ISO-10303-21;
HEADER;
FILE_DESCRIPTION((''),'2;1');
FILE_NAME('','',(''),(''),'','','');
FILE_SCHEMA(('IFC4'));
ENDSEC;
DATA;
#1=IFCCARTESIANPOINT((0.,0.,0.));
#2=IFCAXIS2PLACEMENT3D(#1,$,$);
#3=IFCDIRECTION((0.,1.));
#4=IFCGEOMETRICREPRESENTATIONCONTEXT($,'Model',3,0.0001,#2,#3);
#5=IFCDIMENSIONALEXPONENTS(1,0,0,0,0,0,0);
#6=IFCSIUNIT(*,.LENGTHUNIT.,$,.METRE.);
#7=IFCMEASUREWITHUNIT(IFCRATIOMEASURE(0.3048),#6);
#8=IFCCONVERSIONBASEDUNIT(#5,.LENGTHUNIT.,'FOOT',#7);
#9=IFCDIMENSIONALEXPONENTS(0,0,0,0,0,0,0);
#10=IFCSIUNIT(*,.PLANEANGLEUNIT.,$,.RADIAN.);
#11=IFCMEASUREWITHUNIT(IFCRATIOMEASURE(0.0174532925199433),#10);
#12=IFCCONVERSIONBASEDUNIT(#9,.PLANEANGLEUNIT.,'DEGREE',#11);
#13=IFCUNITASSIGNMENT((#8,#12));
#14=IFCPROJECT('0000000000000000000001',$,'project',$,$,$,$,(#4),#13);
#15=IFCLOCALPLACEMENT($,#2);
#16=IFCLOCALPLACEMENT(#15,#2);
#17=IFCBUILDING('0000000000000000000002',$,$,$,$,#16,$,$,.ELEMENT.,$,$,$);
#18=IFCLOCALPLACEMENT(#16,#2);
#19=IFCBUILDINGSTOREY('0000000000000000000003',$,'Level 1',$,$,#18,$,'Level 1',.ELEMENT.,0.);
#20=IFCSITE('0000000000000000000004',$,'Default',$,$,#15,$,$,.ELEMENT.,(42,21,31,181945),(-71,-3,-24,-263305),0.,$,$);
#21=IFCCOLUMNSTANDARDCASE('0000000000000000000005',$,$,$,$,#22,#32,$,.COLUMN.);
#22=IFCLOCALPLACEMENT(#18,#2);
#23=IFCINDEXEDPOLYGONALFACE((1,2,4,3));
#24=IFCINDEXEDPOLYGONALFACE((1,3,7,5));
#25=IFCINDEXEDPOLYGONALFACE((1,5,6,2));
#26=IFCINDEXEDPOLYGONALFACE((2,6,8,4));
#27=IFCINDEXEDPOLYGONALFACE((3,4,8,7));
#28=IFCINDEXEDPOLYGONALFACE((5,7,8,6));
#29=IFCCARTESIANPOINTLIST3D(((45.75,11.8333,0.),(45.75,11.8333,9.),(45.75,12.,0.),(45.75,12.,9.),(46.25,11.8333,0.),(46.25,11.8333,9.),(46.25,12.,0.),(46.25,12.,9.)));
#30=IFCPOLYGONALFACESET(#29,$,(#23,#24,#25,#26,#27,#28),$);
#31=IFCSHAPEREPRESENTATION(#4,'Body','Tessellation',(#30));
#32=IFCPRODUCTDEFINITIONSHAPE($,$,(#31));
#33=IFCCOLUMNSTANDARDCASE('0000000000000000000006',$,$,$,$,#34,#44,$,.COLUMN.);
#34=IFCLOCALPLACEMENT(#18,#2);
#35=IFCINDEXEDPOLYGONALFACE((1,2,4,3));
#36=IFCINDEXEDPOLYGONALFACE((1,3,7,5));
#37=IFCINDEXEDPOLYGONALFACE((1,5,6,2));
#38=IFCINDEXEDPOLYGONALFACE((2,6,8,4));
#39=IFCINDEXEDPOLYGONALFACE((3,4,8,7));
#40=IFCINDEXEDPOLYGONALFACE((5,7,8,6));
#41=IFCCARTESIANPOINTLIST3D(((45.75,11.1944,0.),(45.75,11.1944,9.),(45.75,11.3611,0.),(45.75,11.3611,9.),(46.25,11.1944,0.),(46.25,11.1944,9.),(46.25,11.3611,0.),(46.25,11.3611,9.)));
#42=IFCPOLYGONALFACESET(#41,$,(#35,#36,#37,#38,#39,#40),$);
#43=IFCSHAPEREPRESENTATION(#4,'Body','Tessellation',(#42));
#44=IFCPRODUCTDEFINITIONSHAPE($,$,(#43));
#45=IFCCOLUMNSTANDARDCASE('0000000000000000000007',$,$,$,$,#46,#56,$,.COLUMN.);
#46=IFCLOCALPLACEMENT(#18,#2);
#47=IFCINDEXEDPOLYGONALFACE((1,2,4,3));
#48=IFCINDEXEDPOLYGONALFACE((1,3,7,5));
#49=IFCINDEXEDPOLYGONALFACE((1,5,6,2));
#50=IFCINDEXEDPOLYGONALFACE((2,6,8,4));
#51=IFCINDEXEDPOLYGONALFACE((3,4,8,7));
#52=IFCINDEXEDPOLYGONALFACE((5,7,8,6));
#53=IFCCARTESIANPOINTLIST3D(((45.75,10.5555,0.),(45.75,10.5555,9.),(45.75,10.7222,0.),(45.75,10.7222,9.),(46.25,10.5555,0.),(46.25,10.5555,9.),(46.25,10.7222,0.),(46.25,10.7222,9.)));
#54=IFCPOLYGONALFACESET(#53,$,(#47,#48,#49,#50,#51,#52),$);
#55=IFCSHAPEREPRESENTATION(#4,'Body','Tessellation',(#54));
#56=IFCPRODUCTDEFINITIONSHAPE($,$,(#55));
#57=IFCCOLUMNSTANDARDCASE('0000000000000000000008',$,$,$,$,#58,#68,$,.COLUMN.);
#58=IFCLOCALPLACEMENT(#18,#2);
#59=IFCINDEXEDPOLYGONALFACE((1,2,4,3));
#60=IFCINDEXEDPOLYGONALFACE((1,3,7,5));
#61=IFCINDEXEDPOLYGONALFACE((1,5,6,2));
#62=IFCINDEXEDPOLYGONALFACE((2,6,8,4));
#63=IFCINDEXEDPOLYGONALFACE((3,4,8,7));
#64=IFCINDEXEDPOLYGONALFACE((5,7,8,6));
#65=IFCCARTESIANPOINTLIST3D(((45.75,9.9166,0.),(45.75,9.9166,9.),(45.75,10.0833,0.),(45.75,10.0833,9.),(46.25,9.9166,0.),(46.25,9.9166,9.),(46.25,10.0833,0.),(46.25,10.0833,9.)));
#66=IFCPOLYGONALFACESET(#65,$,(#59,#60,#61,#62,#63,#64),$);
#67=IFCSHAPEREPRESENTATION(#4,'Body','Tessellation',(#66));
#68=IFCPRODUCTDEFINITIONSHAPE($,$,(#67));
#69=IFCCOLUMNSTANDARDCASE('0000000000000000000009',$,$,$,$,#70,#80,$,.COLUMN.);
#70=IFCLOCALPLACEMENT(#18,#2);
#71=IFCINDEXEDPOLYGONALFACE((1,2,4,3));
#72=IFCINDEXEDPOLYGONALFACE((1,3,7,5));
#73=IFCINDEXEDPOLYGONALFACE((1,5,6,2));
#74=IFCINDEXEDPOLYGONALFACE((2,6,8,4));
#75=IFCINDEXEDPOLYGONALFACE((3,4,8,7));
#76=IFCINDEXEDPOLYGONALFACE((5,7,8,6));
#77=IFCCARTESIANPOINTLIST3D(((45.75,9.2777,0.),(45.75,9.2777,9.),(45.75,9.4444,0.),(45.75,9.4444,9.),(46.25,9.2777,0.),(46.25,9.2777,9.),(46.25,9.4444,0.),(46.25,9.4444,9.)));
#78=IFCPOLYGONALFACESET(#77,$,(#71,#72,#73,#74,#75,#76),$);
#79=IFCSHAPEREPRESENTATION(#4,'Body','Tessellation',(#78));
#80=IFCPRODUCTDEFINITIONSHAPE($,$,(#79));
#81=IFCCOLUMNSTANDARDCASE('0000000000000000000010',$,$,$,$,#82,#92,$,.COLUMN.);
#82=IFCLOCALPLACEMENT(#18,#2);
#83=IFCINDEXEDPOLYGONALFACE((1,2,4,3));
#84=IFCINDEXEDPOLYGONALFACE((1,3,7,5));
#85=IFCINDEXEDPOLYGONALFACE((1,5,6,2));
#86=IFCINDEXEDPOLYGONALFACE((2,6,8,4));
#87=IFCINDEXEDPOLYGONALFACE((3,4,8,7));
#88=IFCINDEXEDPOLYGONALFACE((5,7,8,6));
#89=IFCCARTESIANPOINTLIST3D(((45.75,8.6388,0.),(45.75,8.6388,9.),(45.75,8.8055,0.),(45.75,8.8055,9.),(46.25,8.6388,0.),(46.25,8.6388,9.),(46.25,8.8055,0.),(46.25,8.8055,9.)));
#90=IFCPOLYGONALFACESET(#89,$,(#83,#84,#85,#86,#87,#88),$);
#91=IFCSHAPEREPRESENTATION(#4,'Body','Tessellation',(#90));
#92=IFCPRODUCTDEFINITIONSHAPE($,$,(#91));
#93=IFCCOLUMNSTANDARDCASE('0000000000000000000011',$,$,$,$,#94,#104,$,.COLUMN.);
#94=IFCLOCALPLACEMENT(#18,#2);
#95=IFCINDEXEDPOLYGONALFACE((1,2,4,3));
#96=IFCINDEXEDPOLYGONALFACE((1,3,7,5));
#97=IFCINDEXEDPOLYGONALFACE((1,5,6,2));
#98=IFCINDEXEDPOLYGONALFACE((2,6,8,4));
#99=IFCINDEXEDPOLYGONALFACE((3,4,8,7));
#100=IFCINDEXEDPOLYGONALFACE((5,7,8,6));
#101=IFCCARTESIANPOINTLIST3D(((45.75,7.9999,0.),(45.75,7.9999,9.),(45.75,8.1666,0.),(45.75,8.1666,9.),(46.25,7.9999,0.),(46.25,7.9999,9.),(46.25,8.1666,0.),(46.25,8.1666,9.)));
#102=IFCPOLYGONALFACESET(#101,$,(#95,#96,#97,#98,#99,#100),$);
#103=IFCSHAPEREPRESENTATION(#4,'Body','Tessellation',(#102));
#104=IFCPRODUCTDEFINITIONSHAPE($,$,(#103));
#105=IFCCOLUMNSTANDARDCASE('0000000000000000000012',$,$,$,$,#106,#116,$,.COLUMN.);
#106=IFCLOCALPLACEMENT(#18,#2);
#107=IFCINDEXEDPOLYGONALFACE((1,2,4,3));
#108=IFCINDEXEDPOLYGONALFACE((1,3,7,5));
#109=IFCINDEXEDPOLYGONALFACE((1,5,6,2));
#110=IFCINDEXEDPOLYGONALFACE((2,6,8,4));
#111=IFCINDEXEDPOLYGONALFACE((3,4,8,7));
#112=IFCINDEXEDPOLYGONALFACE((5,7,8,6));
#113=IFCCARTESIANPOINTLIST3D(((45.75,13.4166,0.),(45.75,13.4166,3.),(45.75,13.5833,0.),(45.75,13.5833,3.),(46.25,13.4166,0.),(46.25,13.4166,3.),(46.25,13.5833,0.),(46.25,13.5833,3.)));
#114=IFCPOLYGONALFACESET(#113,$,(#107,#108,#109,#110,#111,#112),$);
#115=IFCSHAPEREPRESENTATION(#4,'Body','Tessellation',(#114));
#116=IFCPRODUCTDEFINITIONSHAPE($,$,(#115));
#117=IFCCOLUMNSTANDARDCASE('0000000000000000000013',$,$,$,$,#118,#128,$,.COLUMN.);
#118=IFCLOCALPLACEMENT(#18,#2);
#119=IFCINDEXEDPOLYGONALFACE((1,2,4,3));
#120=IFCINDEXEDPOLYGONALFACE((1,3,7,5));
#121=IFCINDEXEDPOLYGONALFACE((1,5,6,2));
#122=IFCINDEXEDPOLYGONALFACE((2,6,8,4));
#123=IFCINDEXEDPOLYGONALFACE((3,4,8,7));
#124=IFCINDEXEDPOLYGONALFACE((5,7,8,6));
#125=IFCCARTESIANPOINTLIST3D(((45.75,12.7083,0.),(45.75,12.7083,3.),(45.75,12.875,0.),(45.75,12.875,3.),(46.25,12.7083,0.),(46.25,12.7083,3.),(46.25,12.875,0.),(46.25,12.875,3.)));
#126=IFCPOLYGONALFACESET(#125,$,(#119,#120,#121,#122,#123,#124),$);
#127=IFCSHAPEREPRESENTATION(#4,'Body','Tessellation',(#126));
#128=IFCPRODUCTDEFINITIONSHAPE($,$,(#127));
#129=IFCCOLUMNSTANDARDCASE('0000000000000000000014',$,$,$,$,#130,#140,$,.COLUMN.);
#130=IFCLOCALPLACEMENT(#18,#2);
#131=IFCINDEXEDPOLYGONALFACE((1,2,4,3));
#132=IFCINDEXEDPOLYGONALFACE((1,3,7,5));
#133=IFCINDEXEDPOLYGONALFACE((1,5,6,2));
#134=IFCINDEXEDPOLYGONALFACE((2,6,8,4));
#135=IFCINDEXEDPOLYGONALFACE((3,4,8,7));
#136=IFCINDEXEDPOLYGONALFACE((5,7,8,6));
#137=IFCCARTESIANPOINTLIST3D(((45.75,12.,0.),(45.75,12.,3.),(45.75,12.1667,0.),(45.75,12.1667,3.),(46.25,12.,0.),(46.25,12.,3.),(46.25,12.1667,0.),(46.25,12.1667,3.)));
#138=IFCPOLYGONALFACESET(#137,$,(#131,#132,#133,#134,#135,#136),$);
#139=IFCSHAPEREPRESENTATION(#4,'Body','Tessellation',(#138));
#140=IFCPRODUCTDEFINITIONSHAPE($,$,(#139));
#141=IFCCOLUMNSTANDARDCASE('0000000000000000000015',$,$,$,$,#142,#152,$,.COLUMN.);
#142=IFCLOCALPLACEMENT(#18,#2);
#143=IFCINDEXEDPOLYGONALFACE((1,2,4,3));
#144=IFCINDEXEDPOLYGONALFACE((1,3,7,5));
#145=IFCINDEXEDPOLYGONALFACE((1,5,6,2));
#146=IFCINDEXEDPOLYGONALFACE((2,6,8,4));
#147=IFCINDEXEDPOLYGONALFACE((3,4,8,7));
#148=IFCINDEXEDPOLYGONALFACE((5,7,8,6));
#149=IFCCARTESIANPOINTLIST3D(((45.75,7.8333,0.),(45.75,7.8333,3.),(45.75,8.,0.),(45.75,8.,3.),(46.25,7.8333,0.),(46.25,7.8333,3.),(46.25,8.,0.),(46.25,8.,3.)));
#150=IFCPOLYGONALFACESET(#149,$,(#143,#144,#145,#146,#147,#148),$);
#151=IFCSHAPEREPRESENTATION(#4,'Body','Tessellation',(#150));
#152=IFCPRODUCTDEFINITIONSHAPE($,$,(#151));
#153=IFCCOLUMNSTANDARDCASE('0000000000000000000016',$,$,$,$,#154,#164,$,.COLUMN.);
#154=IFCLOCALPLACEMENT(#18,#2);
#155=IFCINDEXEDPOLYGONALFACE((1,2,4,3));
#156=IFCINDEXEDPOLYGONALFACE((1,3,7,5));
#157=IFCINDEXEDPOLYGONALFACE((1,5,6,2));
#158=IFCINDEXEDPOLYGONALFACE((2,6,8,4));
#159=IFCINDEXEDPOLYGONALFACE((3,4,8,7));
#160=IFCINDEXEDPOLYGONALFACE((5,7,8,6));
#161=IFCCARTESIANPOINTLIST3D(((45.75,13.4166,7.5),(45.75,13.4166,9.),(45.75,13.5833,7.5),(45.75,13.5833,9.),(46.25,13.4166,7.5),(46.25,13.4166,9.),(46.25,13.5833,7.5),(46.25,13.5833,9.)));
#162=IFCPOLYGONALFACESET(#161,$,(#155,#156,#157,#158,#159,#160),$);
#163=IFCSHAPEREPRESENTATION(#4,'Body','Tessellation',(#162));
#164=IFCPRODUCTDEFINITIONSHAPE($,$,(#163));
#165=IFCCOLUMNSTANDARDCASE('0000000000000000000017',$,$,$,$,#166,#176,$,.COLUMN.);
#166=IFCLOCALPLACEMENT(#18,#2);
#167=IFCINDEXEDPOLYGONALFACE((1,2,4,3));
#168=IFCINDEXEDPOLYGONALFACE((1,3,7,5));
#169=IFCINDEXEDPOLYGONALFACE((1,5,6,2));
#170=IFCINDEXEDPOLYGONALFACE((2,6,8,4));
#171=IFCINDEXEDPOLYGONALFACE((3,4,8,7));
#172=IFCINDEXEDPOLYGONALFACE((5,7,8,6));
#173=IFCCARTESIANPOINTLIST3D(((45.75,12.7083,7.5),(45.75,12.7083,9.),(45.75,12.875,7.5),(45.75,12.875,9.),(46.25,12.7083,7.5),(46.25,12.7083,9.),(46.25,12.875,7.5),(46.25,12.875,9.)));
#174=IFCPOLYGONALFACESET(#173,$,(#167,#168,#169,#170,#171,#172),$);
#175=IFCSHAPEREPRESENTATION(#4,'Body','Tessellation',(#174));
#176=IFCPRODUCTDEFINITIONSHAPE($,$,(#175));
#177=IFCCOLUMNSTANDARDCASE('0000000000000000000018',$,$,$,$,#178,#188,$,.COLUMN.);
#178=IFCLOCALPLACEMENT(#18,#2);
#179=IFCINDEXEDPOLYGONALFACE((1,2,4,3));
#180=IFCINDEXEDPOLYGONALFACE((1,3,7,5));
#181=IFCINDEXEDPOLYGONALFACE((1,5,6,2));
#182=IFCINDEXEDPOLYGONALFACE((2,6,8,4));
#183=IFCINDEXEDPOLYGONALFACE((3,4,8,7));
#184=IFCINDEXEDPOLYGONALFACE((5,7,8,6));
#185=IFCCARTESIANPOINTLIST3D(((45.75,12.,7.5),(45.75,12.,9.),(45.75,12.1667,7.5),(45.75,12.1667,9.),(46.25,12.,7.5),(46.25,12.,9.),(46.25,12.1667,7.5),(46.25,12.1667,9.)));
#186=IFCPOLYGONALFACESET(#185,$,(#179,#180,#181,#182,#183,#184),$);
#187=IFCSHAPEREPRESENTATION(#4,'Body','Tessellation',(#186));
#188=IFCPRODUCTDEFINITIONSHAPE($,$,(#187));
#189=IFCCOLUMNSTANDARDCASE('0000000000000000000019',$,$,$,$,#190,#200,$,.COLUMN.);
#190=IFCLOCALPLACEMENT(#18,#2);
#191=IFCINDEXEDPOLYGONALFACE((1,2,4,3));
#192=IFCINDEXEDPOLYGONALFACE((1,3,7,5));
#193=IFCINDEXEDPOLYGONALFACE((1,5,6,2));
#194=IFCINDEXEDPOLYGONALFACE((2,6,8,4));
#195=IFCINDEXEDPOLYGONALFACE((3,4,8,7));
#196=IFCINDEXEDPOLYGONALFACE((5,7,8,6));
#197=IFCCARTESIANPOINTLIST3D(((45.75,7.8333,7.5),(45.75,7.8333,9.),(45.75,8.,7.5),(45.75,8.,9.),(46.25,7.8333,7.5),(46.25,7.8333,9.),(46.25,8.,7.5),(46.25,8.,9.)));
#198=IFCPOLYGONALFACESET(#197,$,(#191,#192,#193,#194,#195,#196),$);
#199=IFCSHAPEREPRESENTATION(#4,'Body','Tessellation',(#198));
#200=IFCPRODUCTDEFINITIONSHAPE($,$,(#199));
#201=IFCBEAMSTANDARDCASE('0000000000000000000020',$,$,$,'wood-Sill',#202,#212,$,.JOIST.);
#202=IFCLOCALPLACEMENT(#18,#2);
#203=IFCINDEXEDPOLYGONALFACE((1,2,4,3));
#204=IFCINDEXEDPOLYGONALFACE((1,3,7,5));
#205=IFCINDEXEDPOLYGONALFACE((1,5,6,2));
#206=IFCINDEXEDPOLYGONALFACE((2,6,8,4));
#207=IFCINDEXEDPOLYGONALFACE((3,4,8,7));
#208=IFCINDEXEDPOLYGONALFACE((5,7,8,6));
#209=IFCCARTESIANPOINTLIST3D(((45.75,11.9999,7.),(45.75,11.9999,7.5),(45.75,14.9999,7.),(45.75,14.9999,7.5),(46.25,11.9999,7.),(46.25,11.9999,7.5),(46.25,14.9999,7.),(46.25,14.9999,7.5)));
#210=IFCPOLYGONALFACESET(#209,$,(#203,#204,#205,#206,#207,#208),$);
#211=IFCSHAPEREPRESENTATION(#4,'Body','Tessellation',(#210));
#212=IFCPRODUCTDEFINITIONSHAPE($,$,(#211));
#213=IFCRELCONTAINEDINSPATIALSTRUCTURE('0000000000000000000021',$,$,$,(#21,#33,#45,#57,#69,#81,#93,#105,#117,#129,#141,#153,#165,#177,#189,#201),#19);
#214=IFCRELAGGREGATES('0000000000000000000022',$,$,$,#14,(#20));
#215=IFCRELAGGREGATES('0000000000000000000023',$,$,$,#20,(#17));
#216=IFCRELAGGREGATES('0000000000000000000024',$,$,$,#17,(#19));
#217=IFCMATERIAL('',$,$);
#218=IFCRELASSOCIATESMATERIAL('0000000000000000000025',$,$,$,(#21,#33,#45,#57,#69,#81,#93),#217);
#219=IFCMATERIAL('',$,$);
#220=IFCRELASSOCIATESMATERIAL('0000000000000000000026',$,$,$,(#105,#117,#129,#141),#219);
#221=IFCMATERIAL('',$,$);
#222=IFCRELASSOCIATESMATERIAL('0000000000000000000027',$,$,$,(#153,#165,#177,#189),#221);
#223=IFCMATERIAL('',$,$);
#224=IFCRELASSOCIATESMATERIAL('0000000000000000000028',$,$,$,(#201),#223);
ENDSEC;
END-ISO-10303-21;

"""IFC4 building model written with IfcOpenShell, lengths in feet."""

from ifc_helpers import new_model, entity, si_unit, converted_unit, direction, frame, origin, place, context, project, spatial, rectangle, extrude, material, element, save


model = new_model("IFC4")

# Units and contexts
model_context = context("Model", 3, precision=0.0001, world=origin(), true_north=direction((0.0, 1.0)))
ifc_project = project(units=[converted_unit("LENGTHUNIT", "FOOT", entity("IfcRatioMeasure", 0.3048), si_unit("LENGTHUNIT", "METRE"), dimensions=[1, 0, 0, 0, 0, 0, 0]), converted_unit("PLANEANGLEUNIT", "DEGREE", entity("IfcRatioMeasure", 0.0174532925199433), si_unit("PLANEANGLEUNIT", "RADIAN"), dimensions=[0, 0, 0, 0, 0, 0, 0])], contexts=[model_context])

# Site, building, storey
site_placement = place(None, origin())
site = spatial("IfcSite", under=ifc_project, at=site_placement, Name="Default", CompositionType="ELEMENT", RefLatitude=(42, 21, 31, 181945), RefLongitude=(-71, -3, -24, -263305), RefElevation=0.0)
building_placement = place(site_placement, origin())
building = spatial("IfcBuilding", under=site, at=building_placement, CompositionType="ELEMENT")
storey_placement = place(building_placement, origin())
storey = spatial("IfcBuildingStorey", under=building, at=storey_placement, Name="Level 1", LongName="Level 1", CompositionType="ELEMENT", Elevation=0.0)

# Columns
ifc_material_1 = material(Name="")
placement_1 = place(storey_placement, frame((46.0, 46.25, 0.0), z_axis=(0.0, 0.0, 1.0), x_axis=(0.0, -1.0, 0.0)))
for number, where, z_axis, x_axis in (
    (1, (34.3334, 0.0, 0.0), (0.0, 0.0, 1.0), (1.0, 0.0, 0.0)),
    (2, (34.9723, 0.0, 0.0), (0.0, 0.0, 1.0), (1.0, 0.0, 0.0)),
    (3, (35.6112, 0.0, 0.0), (0.0, 0.0, 1.0), (1.0, 0.0, 0.0)),
    (4, (36.2501, 0.0, 0.0), (0.0, 0.0, 1.0), (1.0, 0.0, 0.0)),
    (5, (36.889, 0.0, 0.0), (0.0, 0.0, 1.0), (1.0, 0.0, 0.0)),
    (6, (37.5279, 0.0, 0.0), (0.0, 0.0, 1.0), (1.0, 0.0, 0.0)),
    (7, (38.1668, 0.0, 0.0), (0.0, 0.0, 1.0), (1.0, 0.0, 0.0)),
):
    element("IfcColumnStandardCase", number, at=place(placement_1, frame(where, z_axis=z_axis, x_axis=x_axis)), inside=storey, material=ifc_material_1, PredefinedType="COLUMN", context=model_context, shape_type="SweptSolid", body=[
        extrude(rectangle(XDim=0.1667, YDim=0.5), origin(), (0.0, 0.0, 1.0), 9.0),
    ])
ifc_material_2 = material(Name="")
for number, where, z_axis, x_axis in (
    (8, (32.7501, 0.0, 0.0), (0.0, 0.0, 1.0), (1.0, 0.0, 0.0)),
    (9, (33.4584, 0.0, 0.0), (0.0, 0.0, 1.0), (1.0, 0.0, 0.0)),
    (10, (34.1667, 0.0, 0.0), (0.0, 0.0, 1.0), (1.0, 0.0, 0.0)),
    (11, (38.3334, 0.0, 0.0), (0.0, 0.0, 1.0), (1.0, 0.0, 0.0)),
):
    element("IfcColumnStandardCase", number, at=place(placement_1, frame(where, z_axis=z_axis, x_axis=x_axis)), inside=storey, material=ifc_material_2, PredefinedType="COLUMN", context=model_context, shape_type="SweptSolid", body=[
        extrude(rectangle(XDim=0.1667, YDim=0.5), origin(), (0.0, 0.0, 1.0), 3.0),
    ])
ifc_material_3 = material(Name="")
for number, where, z_axis, x_axis in (
    (12, (32.7501, 0.0, 7.5), (0.0, 0.0, 1.0), (1.0, 0.0, 0.0)),
    (13, (33.4584, 0.0, 7.5), (0.0, 0.0, 1.0), (1.0, 0.0, 0.0)),
    (14, (34.1667, 0.0, 7.5), (0.0, 0.0, 1.0), (1.0, 0.0, 0.0)),
    (15, (38.3334, 0.0, 7.5), (0.0, 0.0, 1.0), (1.0, 0.0, 0.0)),
):
    element("IfcColumnStandardCase", number, at=place(placement_1, frame(where, z_axis=z_axis, x_axis=x_axis)), inside=storey, material=ifc_material_3, PredefinedType="COLUMN", context=model_context, shape_type="SweptSolid", body=[
        extrude(rectangle(XDim=0.1667, YDim=0.5), origin(), (0.0, 0.0, 1.0), 1.5),
    ])

# Beam
ifc_material_4 = material(Name="")
for number, where, z_axis, x_axis in (
    (16, (32.7501, 0.0, 7.0), (0.0, 0.0, 1.0), (-1.0, 0.0, 0.0)),
):
    element("IfcBeamStandardCase", number, at=place(placement_1, frame(where, z_axis=z_axis, x_axis=x_axis)), inside=storey, material=ifc_material_4, ObjectType="wood-Sill", PredefinedType="JOIST", context=model_context, shape_type="SweptSolid", body=[
        extrude(rectangle(XDim=3.0, YDim=0.5), origin(), (0.0, 0.0, 1.0), 0.5),
    ])

save(model, "model.ifc")
